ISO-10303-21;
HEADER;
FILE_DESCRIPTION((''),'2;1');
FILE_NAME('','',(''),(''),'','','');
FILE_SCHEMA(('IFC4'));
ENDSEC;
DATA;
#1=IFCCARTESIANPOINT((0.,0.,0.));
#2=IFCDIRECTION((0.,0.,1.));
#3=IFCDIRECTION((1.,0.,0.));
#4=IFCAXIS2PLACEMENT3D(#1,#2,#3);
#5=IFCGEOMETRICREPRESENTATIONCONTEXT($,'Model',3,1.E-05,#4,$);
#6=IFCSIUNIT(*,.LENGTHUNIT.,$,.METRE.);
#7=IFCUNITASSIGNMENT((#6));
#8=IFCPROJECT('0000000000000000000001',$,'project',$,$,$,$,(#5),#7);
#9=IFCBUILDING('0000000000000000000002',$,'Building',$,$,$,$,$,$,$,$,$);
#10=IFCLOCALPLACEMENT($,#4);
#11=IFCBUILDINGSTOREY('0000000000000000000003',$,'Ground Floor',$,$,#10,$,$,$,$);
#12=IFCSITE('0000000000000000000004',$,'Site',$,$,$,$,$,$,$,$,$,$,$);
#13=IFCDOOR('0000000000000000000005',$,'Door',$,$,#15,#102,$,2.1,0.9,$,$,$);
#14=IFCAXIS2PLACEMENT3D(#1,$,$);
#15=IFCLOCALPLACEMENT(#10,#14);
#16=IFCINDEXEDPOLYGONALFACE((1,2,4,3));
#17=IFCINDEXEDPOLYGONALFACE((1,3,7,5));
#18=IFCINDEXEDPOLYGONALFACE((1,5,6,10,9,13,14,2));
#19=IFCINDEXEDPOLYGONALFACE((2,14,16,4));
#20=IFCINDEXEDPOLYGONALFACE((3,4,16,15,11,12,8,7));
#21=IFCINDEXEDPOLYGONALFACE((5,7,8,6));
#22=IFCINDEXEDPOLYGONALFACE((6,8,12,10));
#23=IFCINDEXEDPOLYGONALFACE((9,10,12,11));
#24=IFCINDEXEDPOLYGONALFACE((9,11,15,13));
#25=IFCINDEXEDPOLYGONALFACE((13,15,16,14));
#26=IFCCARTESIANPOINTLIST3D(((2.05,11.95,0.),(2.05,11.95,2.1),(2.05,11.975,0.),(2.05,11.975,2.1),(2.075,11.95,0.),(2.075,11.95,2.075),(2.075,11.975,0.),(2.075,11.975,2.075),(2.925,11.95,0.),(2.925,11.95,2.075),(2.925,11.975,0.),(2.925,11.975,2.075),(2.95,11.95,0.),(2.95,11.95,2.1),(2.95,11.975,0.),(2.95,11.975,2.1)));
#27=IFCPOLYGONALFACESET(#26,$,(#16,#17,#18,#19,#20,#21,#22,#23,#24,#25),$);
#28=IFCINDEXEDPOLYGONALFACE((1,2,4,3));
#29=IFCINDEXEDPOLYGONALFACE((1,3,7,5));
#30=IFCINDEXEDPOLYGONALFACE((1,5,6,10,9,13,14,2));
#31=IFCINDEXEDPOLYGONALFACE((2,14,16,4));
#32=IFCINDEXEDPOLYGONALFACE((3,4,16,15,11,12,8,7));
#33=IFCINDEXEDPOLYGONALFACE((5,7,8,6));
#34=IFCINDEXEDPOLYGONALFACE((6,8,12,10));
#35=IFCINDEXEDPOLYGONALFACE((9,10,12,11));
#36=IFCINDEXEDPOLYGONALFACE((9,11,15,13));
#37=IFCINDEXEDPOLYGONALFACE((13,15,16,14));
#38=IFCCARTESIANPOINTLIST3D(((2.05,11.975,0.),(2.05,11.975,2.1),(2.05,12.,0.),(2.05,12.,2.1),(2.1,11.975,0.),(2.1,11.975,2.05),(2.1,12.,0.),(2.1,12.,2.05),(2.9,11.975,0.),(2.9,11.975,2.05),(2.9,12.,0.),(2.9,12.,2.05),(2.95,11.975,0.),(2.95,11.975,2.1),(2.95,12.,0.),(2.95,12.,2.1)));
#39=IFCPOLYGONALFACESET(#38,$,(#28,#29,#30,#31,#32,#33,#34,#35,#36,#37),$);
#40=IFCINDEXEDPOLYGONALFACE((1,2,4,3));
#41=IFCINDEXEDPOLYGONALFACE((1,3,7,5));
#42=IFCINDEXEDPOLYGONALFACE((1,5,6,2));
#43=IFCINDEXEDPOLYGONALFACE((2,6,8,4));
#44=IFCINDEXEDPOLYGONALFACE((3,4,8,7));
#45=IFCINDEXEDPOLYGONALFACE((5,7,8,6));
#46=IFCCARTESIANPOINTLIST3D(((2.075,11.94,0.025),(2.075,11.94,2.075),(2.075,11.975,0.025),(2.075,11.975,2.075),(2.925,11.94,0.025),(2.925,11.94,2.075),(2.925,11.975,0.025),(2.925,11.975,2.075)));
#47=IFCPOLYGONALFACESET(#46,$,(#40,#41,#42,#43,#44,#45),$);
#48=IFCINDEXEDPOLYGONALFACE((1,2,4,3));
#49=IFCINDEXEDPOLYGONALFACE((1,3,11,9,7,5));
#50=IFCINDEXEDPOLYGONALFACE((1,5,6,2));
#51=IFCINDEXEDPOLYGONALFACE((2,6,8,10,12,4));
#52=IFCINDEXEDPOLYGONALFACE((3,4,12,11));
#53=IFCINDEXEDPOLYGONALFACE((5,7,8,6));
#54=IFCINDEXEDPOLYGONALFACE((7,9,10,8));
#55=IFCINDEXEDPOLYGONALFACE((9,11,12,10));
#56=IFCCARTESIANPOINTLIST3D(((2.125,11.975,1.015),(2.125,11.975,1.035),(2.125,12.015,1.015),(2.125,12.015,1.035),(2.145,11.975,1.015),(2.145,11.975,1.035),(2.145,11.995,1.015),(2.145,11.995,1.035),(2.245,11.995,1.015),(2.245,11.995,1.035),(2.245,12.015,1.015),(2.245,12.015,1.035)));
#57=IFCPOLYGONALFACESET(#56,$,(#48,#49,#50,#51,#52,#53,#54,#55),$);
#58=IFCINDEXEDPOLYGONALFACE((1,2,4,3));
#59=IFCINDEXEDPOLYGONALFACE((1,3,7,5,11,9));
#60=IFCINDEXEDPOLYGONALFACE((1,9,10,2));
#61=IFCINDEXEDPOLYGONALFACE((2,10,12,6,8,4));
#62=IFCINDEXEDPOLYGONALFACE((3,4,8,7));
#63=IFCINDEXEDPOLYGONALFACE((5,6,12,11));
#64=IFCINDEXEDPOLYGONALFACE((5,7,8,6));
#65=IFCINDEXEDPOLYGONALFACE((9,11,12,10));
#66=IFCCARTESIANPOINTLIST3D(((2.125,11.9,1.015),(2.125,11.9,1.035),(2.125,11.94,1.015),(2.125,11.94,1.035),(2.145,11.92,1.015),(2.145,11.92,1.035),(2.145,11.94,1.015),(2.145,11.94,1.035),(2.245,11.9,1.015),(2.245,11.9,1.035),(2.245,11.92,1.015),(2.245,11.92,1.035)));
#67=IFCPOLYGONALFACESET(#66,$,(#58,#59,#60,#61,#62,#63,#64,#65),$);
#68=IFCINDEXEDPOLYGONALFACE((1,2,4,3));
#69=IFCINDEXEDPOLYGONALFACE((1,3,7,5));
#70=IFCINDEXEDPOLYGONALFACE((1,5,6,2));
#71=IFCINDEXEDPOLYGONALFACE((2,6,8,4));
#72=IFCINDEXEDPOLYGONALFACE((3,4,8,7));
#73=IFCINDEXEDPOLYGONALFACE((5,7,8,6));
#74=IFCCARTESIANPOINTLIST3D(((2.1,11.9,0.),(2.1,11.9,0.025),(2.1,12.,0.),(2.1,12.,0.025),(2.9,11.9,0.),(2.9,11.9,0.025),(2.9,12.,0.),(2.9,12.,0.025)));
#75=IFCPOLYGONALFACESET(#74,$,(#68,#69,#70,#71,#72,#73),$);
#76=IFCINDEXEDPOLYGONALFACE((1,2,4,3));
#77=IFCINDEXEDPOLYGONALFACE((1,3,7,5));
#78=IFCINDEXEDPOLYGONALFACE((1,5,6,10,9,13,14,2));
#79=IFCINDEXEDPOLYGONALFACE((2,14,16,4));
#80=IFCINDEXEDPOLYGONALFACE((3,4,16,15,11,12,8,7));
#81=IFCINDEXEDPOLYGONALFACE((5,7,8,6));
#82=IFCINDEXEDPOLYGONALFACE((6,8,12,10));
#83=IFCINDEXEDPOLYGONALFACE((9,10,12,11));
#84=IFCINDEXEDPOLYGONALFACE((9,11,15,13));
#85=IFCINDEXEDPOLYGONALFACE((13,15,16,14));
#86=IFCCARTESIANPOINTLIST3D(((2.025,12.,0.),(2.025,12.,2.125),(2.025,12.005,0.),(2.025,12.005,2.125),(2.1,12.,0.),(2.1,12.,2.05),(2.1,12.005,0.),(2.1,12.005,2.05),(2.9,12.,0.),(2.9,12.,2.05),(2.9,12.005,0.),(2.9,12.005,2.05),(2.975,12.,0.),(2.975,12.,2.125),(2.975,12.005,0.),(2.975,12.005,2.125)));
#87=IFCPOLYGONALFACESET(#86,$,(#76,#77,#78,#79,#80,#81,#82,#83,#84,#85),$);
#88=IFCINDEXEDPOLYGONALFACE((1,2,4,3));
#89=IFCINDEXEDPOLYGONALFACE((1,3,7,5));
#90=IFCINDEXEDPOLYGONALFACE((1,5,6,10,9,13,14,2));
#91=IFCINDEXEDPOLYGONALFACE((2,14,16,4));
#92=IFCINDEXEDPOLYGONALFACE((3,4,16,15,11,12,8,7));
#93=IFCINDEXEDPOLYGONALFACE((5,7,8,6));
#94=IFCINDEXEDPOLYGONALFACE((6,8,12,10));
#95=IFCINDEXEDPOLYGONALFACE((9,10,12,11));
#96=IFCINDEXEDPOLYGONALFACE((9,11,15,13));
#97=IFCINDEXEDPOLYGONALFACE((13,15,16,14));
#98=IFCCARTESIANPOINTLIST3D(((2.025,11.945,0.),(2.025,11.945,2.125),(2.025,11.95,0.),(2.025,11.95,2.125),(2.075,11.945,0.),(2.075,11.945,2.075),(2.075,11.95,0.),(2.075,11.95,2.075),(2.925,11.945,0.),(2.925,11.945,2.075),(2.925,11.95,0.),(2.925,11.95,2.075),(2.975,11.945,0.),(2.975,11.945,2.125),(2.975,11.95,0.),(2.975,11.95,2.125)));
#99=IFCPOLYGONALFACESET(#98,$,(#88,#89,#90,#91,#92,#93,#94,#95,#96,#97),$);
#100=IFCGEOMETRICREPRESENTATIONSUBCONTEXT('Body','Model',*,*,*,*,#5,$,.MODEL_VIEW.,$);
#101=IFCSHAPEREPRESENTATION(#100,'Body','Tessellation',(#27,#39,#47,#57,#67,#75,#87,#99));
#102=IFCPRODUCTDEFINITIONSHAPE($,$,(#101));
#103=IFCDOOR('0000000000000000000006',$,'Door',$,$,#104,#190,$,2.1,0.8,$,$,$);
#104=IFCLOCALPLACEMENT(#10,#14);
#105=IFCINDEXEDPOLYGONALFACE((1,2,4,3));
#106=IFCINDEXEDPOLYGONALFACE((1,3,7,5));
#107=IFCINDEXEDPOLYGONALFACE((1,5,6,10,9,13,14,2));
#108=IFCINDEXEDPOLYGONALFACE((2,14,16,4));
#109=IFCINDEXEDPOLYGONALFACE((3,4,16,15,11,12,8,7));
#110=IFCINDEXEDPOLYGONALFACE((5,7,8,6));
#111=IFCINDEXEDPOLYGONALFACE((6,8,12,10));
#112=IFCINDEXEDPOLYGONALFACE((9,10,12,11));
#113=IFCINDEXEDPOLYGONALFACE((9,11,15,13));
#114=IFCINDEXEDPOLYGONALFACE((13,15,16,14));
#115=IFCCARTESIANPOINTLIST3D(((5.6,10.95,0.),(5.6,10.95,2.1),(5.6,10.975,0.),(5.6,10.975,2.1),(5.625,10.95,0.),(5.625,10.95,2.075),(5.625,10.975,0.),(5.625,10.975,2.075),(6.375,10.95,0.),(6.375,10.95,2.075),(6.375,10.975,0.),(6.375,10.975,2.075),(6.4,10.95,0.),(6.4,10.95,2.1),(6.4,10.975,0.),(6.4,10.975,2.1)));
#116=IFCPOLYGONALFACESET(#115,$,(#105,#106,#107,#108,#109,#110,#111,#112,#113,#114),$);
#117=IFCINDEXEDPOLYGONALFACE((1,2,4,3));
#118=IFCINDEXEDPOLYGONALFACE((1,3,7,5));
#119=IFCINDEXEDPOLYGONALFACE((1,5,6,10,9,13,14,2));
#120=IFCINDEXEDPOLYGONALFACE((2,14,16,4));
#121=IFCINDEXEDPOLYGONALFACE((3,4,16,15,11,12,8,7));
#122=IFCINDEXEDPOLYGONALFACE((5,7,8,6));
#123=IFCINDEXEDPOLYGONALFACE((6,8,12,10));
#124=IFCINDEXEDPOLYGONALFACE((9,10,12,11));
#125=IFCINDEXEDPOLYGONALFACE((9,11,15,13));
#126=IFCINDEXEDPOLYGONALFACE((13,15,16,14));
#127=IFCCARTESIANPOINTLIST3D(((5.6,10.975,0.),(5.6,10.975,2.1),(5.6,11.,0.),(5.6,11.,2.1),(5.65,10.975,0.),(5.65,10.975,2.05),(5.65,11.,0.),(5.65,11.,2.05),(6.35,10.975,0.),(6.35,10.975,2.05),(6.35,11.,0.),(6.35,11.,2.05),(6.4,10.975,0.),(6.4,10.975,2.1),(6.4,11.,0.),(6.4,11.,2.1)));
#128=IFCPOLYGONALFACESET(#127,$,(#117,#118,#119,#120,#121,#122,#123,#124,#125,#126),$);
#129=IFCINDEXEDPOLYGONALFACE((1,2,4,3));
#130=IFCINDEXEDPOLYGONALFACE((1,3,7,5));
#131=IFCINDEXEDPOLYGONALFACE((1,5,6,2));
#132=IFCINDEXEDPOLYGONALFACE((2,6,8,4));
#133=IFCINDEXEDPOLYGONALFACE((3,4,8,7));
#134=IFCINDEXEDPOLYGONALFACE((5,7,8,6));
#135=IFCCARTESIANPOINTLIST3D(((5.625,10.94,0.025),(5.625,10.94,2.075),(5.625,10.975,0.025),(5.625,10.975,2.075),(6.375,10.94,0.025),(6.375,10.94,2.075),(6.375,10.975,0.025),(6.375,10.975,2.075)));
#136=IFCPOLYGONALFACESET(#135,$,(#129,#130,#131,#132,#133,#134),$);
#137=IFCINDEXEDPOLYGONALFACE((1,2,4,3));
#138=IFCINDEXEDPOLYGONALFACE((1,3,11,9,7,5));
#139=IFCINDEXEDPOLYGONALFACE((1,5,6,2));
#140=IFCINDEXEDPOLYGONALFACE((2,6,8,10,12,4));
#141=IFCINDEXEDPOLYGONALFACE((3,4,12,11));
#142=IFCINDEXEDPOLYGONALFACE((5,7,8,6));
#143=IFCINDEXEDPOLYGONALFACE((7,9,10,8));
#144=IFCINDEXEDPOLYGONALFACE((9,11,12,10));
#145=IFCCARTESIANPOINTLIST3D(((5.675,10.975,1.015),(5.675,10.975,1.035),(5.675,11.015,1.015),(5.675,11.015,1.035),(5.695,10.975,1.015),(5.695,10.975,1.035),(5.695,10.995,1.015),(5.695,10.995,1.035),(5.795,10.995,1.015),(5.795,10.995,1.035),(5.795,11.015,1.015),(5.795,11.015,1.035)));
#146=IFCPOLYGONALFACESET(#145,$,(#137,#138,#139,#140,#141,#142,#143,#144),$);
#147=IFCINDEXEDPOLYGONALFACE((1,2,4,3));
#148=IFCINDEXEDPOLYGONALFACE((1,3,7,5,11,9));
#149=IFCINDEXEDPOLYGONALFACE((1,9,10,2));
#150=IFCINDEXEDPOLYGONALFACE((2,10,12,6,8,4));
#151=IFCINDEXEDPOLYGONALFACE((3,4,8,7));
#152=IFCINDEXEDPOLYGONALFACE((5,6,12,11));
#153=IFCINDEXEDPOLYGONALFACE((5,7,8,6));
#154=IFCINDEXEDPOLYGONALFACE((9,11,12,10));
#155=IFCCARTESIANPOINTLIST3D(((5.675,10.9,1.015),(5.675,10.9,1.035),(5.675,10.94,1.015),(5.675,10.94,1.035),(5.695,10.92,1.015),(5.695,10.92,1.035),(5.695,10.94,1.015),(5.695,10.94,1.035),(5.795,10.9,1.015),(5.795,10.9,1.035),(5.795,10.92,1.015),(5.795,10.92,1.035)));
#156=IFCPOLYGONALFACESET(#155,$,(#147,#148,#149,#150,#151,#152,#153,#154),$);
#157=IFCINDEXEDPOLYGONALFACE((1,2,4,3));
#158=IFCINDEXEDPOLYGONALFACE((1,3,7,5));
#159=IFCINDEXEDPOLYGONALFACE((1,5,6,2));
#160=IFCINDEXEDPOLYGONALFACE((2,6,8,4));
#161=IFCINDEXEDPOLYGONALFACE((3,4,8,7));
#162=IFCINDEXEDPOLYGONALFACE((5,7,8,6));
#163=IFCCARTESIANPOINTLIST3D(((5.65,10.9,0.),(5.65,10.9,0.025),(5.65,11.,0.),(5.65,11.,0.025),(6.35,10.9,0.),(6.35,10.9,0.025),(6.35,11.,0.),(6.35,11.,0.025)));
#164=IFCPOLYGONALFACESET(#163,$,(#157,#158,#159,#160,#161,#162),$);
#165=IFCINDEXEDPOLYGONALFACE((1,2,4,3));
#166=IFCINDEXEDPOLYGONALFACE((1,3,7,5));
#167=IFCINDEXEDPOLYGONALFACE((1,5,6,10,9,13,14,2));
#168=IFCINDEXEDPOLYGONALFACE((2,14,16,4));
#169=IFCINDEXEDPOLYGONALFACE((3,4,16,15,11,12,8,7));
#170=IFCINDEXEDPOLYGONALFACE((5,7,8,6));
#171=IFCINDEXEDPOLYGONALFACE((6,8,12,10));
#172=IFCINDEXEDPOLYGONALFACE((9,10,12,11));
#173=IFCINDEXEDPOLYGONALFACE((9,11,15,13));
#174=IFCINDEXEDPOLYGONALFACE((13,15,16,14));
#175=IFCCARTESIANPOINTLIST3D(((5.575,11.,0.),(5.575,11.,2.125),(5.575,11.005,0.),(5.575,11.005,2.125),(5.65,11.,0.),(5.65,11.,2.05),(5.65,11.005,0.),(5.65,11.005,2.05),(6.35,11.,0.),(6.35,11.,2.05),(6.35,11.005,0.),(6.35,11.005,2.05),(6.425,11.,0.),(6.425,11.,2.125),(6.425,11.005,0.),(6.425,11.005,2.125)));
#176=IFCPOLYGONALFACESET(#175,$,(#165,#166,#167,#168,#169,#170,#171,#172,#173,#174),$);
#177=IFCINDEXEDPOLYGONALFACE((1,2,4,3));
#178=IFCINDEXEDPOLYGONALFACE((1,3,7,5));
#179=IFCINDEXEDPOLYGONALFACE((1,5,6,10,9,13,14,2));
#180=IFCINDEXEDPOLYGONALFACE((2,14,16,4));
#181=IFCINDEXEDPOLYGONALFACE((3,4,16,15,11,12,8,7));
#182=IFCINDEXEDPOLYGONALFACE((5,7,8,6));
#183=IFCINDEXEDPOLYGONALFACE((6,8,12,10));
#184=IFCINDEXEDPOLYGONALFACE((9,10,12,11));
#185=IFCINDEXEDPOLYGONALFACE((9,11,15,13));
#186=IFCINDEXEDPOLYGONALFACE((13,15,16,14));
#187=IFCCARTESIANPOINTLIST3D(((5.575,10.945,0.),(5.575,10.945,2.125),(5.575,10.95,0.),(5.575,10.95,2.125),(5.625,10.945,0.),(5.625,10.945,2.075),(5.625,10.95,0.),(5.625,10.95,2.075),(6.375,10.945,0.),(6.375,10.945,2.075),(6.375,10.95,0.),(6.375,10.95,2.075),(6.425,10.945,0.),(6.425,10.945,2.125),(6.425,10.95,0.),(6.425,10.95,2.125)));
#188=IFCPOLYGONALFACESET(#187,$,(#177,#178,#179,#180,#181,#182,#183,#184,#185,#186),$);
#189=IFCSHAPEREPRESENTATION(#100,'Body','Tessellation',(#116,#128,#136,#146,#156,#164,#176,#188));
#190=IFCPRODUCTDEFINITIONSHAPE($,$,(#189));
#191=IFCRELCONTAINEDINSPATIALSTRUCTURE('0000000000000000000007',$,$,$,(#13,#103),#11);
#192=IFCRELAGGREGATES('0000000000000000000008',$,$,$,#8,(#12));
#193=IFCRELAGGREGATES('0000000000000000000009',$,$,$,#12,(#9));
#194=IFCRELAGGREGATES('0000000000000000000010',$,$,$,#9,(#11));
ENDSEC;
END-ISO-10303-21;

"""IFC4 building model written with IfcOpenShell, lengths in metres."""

from ifc_helpers import new_model, si_unit, frame, origin_with_axes, place, context, subcontext, project, spatial, line, indexed_curve, outline, extrude, element, save


model = new_model("IFC4")

# Units and contexts
model_context = context("Model", 3, precision=1e-05, world=origin_with_axes())
body_context = subcontext(model_context, "Body", "Model", "MODEL_VIEW")
ifc_project = project(units=[si_unit("LENGTHUNIT", "METRE")], contexts=[model_context])

# Site, building, storey
site = spatial("IfcSite", under=ifc_project, Name="Site")
building = spatial("IfcBuilding", under=site, Name="Building")
storey_placement = place(None, origin_with_axes())
storey = spatial("IfcBuildingStorey", under=building, at=storey_placement, Name="Ground Floor")

# Doors
door_1_placement = place(storey_placement, frame((2.95, 12.0, 0.0), z_axis=(0.0, 0.0, 1.0), x_axis=(-1.0, 0.0, 0.0)))
element("IfcDoor", 1, at=door_1_placement, inside=storey, Name="Door", OverallHeight=2.1, OverallWidth=0.9, context=body_context, shape_type="SweptSolid", body=[
    extrude(outline(indexed_curve([(0.0, 0.0), (0.0, 2.1), (0.9, 2.1), (0.9, 0.0), (0.875, 0.0), (0.875, 2.075), (0.025, 2.075), (0.025, 0.0)], segments=[line(1, 2, 3, 4, 5, 6, 7, 8, 1)])), frame((0.0, 0.025, 0.0), z_axis=(0.0, -1.0, 0.0), x_axis=(1.0, 0.0, 0.0)), (0.0, 0.0, -1.0), 0.025),
    extrude(outline(indexed_curve([(0.0, 0.0), (0.0, 2.1), (0.9, 2.1), (0.9, 0.0), (0.85, 0.0), (0.85, 2.05), (0.05, 2.05), (0.05, 0.0)], segments=[line(1, 2, 3, 4, 5, 6, 7, 8, 1)])), frame((0.0, 0.0, 0.0), z_axis=(0.0, -1.0, 0.0), x_axis=(1.0, 0.0, 0.0)), (0.0, 0.0, -1.0), 0.025),
    extrude(outline(indexed_curve([(0.0, 0.0), (0.85, 0.0), (0.85, 0.035), (0.0, 0.035)], segments=[line(1, 2, 3, 4, 1)])), frame((0.025, 0.025, 0.025), z_axis=(0.0, 0.0, 1.0), x_axis=(1.0, 0.0, 0.0)), (0.0, 0.0, 1.0), 2.05),
    extrude(outline(indexed_curve([(0.0, 0.0), (0.0, -0.04), (-0.12, -0.04), (-0.12, -0.02), (-0.02, -0.02), (-0.02, 0.0)], segments=[line(1, 2, 3, 4, 5, 6, 1)])), frame((0.825, 0.025, 1.015), z_axis=(0.0, 0.0, 1.0), x_axis=(1.0, 0.0, 0.0)), (0.0, 0.0, 1.0), 0.02),
    extrude(outline(indexed_curve([(0.0, 0.0), (0.0, 0.04), (-0.12, 0.04), (-0.12, 0.02), (-0.02, 0.02), (-0.02, 0.0)], segments=[line(1, 2, 3, 4, 5, 6, 1)])), frame((0.825, 0.06, 1.015), z_axis=(0.0, 0.0, 1.0), x_axis=(1.0, 0.0, 0.0)), (0.0, 0.0, 1.0), 0.02),
    extrude(outline(indexed_curve([(0.0, 0.0), (0.8, 0.0), (0.8, 0.1), (0.0, 0.1)], segments=[line(1, 2, 3, 4, 1)])), frame((0.05, 0.0, 0.0), z_axis=(0.0, 0.0, 1.0), x_axis=(1.0, 0.0, 0.0)), (0.0, 0.0, 1.0), 0.025),
    extrude(outline(indexed_curve([(0.0, 0.0), (0.0, 2.125), (0.95, 2.125), (0.95, 0.0), (0.875, 0.0), (0.875, 2.05), (0.075, 2.05), (0.075, 0.0)], segments=[line(1, 2, 3, 4, 5, 6, 7, 8, 1)])), frame((-0.025, -0.005, 0.0), z_axis=(0.0, -1.0, 0.0), x_axis=(1.0, 0.0, 0.0)), (0.0, 0.0, -1.0), 0.005),
    extrude(outline(indexed_curve([(0.0, 0.0), (0.0, 2.125), (0.95, 2.125), (0.95, 0.0), (0.9, 0.0), (0.9, 2.075), (0.05, 2.075), (0.05, 0.0)], segments=[line(1, 2, 3, 4, 5, 6, 7, 8, 1)])), frame((-0.025, 0.05, 0.0), z_axis=(0.0, -1.0, 0.0), x_axis=(1.0, 0.0, 0.0)), (0.0, 0.0, -1.0), 0.005),
])
door_2_placement = place(storey_placement, frame((6.4, 11.0, 0.0), z_axis=(0.0, 0.0, 1.0), x_axis=(-1.0, 0.0, 0.0)))
element("IfcDoor", 2, at=door_2_placement, inside=storey, Name="Door", OverallHeight=2.1, OverallWidth=0.8, context=body_context, shape_type="SweptSolid", body=[
    extrude(outline(indexed_curve([(0.0, 0.0), (0.0, 2.1), (0.8, 2.1), (0.8, 0.0), (0.775, 0.0), (0.775, 2.075), (0.025, 2.075), (0.025, 0.0)], segments=[line(1, 2, 3, 4, 5, 6, 7, 8, 1)])), frame((0.0, 0.025, 0.0), z_axis=(0.0, -1.0, 0.0), x_axis=(1.0, 0.0, 0.0)), (0.0, 0.0, -1.0), 0.025),
    extrude(outline(indexed_curve([(0.0, 0.0), (0.0, 2.1), (0.8, 2.1), (0.8, 0.0), (0.75, 0.0), (0.75, 2.05), (0.05, 2.05), (0.05, 0.0)], segments=[line(1, 2, 3, 4, 5, 6, 7, 8, 1)])), frame((0.0, 0.0, 0.0), z_axis=(0.0, -1.0, 0.0), x_axis=(1.0, 0.0, 0.0)), (0.0, 0.0, -1.0), 0.025),
    extrude(outline(indexed_curve([(0.0, 0.0), (0.75, 0.0), (0.75, 0.035), (0.0, 0.035)], segments=[line(1, 2, 3, 4, 1)])), frame((0.025, 0.025, 0.025), z_axis=(0.0, 0.0, 1.0), x_axis=(1.0, 0.0, 0.0)), (0.0, 0.0, 1.0), 2.05),
    extrude(outline(indexed_curve([(0.0, 0.0), (0.0, -0.04), (-0.12, -0.04), (-0.12, -0.02), (-0.02, -0.02), (-0.02, 0.0)], segments=[line(1, 2, 3, 4, 5, 6, 1)])), frame((0.725, 0.025, 1.015), z_axis=(0.0, 0.0, 1.0), x_axis=(1.0, 0.0, 0.0)), (0.0, 0.0, 1.0), 0.02),
    extrude(outline(indexed_curve([(0.0, 0.0), (0.0, 0.04), (-0.12, 0.04), (-0.12, 0.02), (-0.02, 0.02), (-0.02, 0.0)], segments=[line(1, 2, 3, 4, 5, 6, 1)])), frame((0.725, 0.06, 1.015), z_axis=(0.0, 0.0, 1.0), x_axis=(1.0, 0.0, 0.0)), (0.0, 0.0, 1.0), 0.02),
    extrude(outline(indexed_curve([(0.0, 0.0), (0.7, 0.0), (0.7, 0.1), (0.0, 0.1)], segments=[line(1, 2, 3, 4, 1)])), frame((0.05, 0.0, 0.0), z_axis=(0.0, 0.0, 1.0), x_axis=(1.0, 0.0, 0.0)), (0.0, 0.0, 1.0), 0.025),
    extrude(outline(indexed_curve([(0.0, 0.0), (0.0, 2.125), (0.85, 2.125), (0.85, 0.0), (0.775, 0.0), (0.775, 2.05), (0.075, 2.05), (0.075, 0.0)], segments=[line(1, 2, 3, 4, 5, 6, 7, 8, 1)])), frame((-0.025, -0.005, 0.0), z_axis=(0.0, -1.0, 0.0), x_axis=(1.0, 0.0, 0.0)), (0.0, 0.0, -1.0), 0.005),
    extrude(outline(indexed_curve([(0.0, 0.0), (0.0, 2.125), (0.85, 2.125), (0.85, 0.0), (0.8, 0.0), (0.8, 2.075), (0.05, 2.075), (0.05, 0.0)], segments=[line(1, 2, 3, 4, 5, 6, 7, 8, 1)])), frame((-0.025, 0.05, 0.0), z_axis=(0.0, -1.0, 0.0), x_axis=(1.0, 0.0, 0.0)), (0.0, 0.0, -1.0), 0.005),
])

save(model, "model.ifc")
